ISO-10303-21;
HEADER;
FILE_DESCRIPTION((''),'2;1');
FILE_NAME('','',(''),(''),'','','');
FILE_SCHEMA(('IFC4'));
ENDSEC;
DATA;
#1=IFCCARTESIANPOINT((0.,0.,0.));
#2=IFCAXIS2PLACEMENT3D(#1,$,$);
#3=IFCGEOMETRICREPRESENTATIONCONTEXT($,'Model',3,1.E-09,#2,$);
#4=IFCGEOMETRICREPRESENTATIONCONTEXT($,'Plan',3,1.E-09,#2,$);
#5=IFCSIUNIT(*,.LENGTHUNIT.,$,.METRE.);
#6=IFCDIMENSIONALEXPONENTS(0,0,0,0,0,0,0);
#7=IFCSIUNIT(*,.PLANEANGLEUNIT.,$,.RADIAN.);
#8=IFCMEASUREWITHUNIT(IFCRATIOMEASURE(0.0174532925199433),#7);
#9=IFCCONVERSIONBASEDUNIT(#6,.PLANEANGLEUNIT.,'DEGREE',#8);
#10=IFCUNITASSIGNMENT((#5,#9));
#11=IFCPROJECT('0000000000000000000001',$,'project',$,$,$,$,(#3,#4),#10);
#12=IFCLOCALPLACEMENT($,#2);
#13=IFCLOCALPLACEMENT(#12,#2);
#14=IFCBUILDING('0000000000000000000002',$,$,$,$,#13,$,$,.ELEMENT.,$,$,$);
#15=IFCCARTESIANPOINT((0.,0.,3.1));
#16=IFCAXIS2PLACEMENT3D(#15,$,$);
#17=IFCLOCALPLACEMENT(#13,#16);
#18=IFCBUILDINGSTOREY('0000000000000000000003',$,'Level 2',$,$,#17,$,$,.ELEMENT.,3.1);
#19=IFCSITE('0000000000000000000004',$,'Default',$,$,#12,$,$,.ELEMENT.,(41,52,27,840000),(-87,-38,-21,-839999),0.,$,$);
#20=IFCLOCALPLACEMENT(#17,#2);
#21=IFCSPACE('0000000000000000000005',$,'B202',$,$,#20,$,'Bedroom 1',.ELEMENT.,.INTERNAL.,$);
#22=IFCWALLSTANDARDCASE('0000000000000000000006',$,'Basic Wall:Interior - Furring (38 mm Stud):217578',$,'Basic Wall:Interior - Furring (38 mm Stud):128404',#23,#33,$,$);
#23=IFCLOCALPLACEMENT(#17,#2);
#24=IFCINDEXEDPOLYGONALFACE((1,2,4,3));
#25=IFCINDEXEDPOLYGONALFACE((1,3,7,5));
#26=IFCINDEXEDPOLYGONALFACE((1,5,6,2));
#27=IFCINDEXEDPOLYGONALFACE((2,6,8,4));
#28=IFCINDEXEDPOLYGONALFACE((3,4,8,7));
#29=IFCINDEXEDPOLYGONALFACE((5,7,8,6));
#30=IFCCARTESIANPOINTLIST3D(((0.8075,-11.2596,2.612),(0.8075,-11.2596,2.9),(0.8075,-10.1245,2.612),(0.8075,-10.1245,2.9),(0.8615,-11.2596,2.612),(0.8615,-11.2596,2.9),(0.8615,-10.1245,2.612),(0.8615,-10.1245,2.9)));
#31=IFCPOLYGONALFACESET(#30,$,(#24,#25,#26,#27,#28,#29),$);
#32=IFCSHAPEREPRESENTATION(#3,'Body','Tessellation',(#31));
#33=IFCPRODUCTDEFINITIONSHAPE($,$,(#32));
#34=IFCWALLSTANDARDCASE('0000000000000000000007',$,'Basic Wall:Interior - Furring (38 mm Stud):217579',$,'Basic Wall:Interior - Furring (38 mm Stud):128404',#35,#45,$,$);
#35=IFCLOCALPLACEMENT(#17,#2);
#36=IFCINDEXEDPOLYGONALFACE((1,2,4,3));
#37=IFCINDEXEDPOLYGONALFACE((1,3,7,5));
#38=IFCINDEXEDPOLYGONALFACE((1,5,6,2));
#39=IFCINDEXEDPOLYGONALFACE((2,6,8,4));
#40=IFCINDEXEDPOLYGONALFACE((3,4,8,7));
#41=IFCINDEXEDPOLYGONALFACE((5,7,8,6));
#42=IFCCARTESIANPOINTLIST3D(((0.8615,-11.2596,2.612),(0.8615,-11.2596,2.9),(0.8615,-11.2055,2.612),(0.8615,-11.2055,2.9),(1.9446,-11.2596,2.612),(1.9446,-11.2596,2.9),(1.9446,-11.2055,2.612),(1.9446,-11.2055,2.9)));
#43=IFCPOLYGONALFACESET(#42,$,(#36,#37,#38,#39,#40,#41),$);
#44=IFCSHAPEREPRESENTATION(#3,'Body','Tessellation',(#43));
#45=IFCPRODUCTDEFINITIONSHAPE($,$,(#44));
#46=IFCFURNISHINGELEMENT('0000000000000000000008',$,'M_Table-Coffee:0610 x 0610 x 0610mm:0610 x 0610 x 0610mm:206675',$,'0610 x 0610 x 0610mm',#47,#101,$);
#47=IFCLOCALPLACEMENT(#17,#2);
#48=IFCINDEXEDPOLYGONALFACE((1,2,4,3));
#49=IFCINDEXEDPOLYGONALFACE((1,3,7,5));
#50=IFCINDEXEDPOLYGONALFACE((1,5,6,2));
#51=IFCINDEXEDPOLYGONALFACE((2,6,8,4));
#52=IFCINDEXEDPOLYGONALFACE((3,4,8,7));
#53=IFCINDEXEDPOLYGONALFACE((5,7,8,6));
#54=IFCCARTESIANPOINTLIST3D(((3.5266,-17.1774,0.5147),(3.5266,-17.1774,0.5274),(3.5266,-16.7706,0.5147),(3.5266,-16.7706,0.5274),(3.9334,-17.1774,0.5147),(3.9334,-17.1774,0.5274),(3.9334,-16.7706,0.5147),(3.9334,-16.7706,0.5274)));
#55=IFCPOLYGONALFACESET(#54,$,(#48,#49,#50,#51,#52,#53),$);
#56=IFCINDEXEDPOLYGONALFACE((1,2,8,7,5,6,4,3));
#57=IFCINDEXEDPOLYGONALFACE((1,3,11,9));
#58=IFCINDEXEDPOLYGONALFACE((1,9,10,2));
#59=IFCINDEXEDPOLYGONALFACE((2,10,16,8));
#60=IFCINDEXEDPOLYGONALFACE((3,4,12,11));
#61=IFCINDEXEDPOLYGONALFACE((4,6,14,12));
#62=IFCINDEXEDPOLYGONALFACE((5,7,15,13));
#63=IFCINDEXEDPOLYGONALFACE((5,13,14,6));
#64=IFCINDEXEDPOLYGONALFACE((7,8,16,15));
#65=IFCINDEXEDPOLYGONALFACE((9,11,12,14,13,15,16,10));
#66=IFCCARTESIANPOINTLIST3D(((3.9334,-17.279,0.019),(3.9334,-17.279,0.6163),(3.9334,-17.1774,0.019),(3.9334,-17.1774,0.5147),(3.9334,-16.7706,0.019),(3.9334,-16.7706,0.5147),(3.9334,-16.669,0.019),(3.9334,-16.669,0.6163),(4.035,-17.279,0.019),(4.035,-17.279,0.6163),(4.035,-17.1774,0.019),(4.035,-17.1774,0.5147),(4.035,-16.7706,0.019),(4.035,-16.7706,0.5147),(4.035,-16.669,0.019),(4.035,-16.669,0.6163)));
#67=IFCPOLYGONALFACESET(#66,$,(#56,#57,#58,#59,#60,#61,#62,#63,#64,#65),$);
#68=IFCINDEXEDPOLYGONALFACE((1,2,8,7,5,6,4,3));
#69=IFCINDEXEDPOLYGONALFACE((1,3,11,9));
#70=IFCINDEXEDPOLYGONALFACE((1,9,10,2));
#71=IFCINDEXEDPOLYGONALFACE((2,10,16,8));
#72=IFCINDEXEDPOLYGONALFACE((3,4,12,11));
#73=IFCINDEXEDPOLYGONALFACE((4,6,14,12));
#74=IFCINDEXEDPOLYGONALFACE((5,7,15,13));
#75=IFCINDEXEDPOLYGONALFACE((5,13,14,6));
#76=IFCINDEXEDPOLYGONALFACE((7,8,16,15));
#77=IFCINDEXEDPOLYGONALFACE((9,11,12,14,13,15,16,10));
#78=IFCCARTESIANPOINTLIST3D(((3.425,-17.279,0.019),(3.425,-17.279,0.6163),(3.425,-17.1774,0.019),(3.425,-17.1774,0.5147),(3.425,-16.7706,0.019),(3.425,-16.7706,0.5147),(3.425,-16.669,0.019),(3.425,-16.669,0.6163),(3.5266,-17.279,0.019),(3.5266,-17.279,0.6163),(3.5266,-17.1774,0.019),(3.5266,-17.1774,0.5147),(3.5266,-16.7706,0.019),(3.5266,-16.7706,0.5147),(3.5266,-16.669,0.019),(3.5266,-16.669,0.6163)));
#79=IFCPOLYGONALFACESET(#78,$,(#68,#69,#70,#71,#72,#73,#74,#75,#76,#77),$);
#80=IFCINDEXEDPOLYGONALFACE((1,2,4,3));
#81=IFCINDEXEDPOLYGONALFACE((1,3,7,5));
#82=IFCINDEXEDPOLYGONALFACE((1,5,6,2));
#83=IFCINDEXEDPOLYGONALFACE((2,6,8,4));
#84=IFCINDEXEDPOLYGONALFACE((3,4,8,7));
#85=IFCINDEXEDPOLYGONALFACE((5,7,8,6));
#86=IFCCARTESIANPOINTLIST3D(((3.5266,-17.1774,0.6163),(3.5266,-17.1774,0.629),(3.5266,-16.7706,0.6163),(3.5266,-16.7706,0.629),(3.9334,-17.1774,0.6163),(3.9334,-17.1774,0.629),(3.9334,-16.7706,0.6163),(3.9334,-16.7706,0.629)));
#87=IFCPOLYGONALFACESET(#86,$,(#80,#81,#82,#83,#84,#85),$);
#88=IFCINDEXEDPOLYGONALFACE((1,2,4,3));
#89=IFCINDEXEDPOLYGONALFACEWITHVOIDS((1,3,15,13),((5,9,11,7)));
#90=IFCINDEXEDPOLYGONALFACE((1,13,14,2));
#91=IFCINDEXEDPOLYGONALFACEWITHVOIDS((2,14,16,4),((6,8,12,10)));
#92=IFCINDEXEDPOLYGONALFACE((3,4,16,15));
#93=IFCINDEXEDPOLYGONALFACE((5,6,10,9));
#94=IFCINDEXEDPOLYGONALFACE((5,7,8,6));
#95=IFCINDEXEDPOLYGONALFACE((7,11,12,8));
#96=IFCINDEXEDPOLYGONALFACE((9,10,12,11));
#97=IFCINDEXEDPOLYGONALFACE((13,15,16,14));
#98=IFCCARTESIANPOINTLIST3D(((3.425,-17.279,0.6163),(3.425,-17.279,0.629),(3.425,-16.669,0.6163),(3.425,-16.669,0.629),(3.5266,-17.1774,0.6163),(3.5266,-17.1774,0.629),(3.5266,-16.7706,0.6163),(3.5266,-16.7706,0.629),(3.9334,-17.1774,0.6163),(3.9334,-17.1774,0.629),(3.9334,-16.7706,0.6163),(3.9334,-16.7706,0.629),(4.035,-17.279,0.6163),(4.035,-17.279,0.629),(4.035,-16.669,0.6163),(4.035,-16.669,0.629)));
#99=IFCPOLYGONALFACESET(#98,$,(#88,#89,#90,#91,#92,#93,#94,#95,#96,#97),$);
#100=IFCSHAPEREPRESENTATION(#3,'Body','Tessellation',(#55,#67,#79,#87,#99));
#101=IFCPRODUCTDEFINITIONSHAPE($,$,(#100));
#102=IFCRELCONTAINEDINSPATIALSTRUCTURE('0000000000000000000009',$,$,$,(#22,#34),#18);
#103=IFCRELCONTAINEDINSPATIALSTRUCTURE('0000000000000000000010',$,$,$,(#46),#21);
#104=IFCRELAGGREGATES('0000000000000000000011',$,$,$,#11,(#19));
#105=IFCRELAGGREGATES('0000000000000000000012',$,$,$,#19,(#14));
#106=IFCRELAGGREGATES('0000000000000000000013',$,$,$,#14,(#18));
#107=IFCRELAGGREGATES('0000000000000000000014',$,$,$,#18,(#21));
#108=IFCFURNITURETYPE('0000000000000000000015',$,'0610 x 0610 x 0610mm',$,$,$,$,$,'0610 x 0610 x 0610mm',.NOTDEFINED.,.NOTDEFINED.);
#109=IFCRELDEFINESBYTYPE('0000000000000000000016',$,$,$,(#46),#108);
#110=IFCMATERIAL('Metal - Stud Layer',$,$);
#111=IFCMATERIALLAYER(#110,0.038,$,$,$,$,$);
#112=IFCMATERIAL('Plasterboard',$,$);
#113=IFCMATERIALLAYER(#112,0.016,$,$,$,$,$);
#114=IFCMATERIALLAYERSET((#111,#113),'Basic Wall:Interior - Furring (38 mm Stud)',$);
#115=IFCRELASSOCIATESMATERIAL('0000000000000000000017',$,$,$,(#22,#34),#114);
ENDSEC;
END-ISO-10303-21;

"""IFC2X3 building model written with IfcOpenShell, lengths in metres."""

from ifc_helpers import new_model, entity, si_unit, converted_unit, frame, frame_2d, origin, origin_2d_with_axis, place, context, project, spatial, polyline, rectangle, outline, extrude, source, transform, mapped, material, layer, layer_set, layer_usage, type_object, type_shapes, element, save


model = new_model("IFC2X3")

# Units and contexts
model_context = context("Model", 3, precision=1e-09, world=origin())
plan_context = context("Plan", 3, precision=1e-09, world=origin())
ifc_project = project(units=[si_unit("LENGTHUNIT", "METRE"), converted_unit("PLANEANGLEUNIT", "DEGREE", entity("IfcRatioMeasure", 0.0174532925199433), si_unit("PLANEANGLEUNIT", "RADIAN"), dimensions=[0, 0, 0, 0, 0, 0, 0])], contexts=[model_context, plan_context])

# Site, building, storey
site_placement = place(None, origin())
site = spatial("IfcSite", under=ifc_project, at=site_placement, Name="Default", CompositionType="ELEMENT", RefLatitude=(41, 52, 27, 840000), RefLongitude=(-87, -38, -21, -839999), RefElevation=0.0)
building_placement = place(site_placement, origin())
building = spatial("IfcBuilding", under=site, at=building_placement, CompositionType="ELEMENT")
storey_placement = place(building_placement, frame((0.0, 0.0, 3.1)))
storey = spatial("IfcBuildingStorey", under=building, at=storey_placement, Name="Level 2", CompositionType="ELEMENT", Elevation=3.1)

# Shared definitions
ifc_material_1 = material(Name="Metal - Stud Layer")
ifc_material_2 = material(Name="Plasterboard")

# Walls
ifc_layer_1 = layer(ifc_material_1, 0.038)
ifc_layer_2 = layer(ifc_material_2, 0.016)
ifc_layer_set_1 = layer_set([ifc_layer_1, ifc_layer_2], Name="Basic Wall:Interior - Furring (38 mm Stud)")
ifc_layer_usage_1 = layer_usage(ifc_layer_set_1, "AXIS2", "NEGATIVE", 0.027)
wall_1_placement = place(storey_placement, frame((0.8345, -11.2596, 2.612), z_axis=(0.0, 0.0, 1.0), x_axis=(0.0, 1.0, 0.0)))
element("IfcWallStandardCase", 1, at=wall_1_placement, inside=storey, material=ifc_layer_usage_1, Name="Basic Wall:Interior - Furring (38 mm Stud):217578", ObjectType="Basic Wall:Interior - Furring (38 mm Stud):128404", context=model_context, shape_type="SweptSolid", body=[
    extrude(rectangle(XDim=1.1351, YDim=0.054, at=frame_2d((0.5675, 0.0), x_axis=(-1.0, 0.0))), origin(), (0.0, 0.0, 1.0), 0.288),
])
wall_2_placement = place(storey_placement, frame((1.9446, -11.2325, 2.612), z_axis=(0.0, 0.0, 1.0), x_axis=(-1.0, 0.0, 0.0)))
element("IfcWallStandardCase", 2, at=wall_2_placement, inside=storey, material=ifc_layer_usage_1, Name="Basic Wall:Interior - Furring (38 mm Stud):217579", ObjectType="Basic Wall:Interior - Furring (38 mm Stud):128404", context=model_context, shape_type="SweptSolid", body=[
    extrude(rectangle(XDim=1.0831, YDim=0.054, at=frame_2d((0.5415, 0.0), x_axis=(-1.0, 0.0))), origin(), (0.0, 0.0, 1.0), 0.288),
])

# Shared definitions
space_placement = place(storey_placement, origin())
space = spatial("IfcSpace", under=storey, at=space_placement, Name="B202", LongName="Bedroom 1", CompositionType="ELEMENT", InteriorOrExteriorSpace="INTERNAL")

# Furnishing element
furniture_type = type_object("IfcFurnitureType", Name="0610 x 0610 x 0610mm", ElementType="0610 x 0610 x 0610mm", AssemblyPlace="NOTDEFINED")
shared_shape_1 = source(origin(), model_context, "Body", "SweptSolid", [
    extrude(rectangle(XDim=0.4068, YDim=0.4068, at=origin_2d_with_axis()), frame((0.0183, 0.0952, 0.4957), z_axis=(0.0, 0.0, 1.0), x_axis=(-1.0, 0.0, 0.0)), (0.0, 0.0, 1.0), 0.0127),
    extrude(outline(polyline([(-0.2732, -0.305), (0.324, -0.305), (0.324, 0.305), (-0.2732, 0.305), (-0.2732, 0.2034), (0.2225, 0.2034), (0.2225, -0.2034), (-0.2732, -0.2034), (-0.2732, -0.305)])), frame((0.2217, 0.0952, 0.2732), z_axis=(1.0, 0.0, 0.0), x_axis=(0.0, 0.0, 1.0)), (0.0, 0.0, 1.0), 0.1016),
    extrude(outline(polyline([(-0.305, -0.3241), (0.305, -0.3241), (0.305, 0.2733), (0.2034, 0.2733), (0.2034, -0.2224), (-0.2034, -0.2224), (-0.2034, 0.2733), (-0.305, 0.2733), (-0.305, -0.3241)])), frame((-0.2867, 0.0952, 0.2733), z_axis=(1.0, 0.0, 0.0), x_axis=(0.0, -1.0, 0.0)), (0.0, 0.0, 1.0), 0.1016),
    extrude(rectangle(XDim=0.4068, YDim=0.4068, at=origin_2d_with_axis()), frame((0.0183, 0.0952, 0.5973), z_axis=(0.0, 0.0, 1.0), x_axis=(-1.0, 0.0, 0.0)), (0.0, 0.0, 1.0), 0.0127),
    extrude(outline(polyline([(-0.305, -0.305), (0.305, -0.305), (0.305, 0.305), (-0.305, 0.305), (-0.305, -0.305)]), holes=[polyline([(-0.2034, -0.2034), (-0.2034, 0.2034), (0.2034, 0.2034), (0.2034, -0.2034), (-0.2034, -0.2034)])]), frame((0.0183, 0.0952, 0.5973), z_axis=(0.0, 0.0, 1.0), x_axis=(-1.0, 0.0, 0.0)), (0.0, 0.0, 1.0), 0.0127),
])
type_shapes(furniture_type, [shared_shape_1])
furnishing_placement = place(space_placement, frame((3.7117, -17.0692, 0.019)))
element("IfcFurnishingElement", 3, at=furnishing_placement, inside=space, type_object=furniture_type, Name="M_Table-Coffee:0610 x 0610 x 0610mm:0610 x 0610 x 0610mm:206675", ObjectType="0610 x 0610 x 0610mm", context=model_context, shape_type="MappedRepresentation", body=[
    mapped(shared_shape_1, transform((0.0, 0.0, 0.0), scale=1.0)),
])

save(model, "model.ifc")
